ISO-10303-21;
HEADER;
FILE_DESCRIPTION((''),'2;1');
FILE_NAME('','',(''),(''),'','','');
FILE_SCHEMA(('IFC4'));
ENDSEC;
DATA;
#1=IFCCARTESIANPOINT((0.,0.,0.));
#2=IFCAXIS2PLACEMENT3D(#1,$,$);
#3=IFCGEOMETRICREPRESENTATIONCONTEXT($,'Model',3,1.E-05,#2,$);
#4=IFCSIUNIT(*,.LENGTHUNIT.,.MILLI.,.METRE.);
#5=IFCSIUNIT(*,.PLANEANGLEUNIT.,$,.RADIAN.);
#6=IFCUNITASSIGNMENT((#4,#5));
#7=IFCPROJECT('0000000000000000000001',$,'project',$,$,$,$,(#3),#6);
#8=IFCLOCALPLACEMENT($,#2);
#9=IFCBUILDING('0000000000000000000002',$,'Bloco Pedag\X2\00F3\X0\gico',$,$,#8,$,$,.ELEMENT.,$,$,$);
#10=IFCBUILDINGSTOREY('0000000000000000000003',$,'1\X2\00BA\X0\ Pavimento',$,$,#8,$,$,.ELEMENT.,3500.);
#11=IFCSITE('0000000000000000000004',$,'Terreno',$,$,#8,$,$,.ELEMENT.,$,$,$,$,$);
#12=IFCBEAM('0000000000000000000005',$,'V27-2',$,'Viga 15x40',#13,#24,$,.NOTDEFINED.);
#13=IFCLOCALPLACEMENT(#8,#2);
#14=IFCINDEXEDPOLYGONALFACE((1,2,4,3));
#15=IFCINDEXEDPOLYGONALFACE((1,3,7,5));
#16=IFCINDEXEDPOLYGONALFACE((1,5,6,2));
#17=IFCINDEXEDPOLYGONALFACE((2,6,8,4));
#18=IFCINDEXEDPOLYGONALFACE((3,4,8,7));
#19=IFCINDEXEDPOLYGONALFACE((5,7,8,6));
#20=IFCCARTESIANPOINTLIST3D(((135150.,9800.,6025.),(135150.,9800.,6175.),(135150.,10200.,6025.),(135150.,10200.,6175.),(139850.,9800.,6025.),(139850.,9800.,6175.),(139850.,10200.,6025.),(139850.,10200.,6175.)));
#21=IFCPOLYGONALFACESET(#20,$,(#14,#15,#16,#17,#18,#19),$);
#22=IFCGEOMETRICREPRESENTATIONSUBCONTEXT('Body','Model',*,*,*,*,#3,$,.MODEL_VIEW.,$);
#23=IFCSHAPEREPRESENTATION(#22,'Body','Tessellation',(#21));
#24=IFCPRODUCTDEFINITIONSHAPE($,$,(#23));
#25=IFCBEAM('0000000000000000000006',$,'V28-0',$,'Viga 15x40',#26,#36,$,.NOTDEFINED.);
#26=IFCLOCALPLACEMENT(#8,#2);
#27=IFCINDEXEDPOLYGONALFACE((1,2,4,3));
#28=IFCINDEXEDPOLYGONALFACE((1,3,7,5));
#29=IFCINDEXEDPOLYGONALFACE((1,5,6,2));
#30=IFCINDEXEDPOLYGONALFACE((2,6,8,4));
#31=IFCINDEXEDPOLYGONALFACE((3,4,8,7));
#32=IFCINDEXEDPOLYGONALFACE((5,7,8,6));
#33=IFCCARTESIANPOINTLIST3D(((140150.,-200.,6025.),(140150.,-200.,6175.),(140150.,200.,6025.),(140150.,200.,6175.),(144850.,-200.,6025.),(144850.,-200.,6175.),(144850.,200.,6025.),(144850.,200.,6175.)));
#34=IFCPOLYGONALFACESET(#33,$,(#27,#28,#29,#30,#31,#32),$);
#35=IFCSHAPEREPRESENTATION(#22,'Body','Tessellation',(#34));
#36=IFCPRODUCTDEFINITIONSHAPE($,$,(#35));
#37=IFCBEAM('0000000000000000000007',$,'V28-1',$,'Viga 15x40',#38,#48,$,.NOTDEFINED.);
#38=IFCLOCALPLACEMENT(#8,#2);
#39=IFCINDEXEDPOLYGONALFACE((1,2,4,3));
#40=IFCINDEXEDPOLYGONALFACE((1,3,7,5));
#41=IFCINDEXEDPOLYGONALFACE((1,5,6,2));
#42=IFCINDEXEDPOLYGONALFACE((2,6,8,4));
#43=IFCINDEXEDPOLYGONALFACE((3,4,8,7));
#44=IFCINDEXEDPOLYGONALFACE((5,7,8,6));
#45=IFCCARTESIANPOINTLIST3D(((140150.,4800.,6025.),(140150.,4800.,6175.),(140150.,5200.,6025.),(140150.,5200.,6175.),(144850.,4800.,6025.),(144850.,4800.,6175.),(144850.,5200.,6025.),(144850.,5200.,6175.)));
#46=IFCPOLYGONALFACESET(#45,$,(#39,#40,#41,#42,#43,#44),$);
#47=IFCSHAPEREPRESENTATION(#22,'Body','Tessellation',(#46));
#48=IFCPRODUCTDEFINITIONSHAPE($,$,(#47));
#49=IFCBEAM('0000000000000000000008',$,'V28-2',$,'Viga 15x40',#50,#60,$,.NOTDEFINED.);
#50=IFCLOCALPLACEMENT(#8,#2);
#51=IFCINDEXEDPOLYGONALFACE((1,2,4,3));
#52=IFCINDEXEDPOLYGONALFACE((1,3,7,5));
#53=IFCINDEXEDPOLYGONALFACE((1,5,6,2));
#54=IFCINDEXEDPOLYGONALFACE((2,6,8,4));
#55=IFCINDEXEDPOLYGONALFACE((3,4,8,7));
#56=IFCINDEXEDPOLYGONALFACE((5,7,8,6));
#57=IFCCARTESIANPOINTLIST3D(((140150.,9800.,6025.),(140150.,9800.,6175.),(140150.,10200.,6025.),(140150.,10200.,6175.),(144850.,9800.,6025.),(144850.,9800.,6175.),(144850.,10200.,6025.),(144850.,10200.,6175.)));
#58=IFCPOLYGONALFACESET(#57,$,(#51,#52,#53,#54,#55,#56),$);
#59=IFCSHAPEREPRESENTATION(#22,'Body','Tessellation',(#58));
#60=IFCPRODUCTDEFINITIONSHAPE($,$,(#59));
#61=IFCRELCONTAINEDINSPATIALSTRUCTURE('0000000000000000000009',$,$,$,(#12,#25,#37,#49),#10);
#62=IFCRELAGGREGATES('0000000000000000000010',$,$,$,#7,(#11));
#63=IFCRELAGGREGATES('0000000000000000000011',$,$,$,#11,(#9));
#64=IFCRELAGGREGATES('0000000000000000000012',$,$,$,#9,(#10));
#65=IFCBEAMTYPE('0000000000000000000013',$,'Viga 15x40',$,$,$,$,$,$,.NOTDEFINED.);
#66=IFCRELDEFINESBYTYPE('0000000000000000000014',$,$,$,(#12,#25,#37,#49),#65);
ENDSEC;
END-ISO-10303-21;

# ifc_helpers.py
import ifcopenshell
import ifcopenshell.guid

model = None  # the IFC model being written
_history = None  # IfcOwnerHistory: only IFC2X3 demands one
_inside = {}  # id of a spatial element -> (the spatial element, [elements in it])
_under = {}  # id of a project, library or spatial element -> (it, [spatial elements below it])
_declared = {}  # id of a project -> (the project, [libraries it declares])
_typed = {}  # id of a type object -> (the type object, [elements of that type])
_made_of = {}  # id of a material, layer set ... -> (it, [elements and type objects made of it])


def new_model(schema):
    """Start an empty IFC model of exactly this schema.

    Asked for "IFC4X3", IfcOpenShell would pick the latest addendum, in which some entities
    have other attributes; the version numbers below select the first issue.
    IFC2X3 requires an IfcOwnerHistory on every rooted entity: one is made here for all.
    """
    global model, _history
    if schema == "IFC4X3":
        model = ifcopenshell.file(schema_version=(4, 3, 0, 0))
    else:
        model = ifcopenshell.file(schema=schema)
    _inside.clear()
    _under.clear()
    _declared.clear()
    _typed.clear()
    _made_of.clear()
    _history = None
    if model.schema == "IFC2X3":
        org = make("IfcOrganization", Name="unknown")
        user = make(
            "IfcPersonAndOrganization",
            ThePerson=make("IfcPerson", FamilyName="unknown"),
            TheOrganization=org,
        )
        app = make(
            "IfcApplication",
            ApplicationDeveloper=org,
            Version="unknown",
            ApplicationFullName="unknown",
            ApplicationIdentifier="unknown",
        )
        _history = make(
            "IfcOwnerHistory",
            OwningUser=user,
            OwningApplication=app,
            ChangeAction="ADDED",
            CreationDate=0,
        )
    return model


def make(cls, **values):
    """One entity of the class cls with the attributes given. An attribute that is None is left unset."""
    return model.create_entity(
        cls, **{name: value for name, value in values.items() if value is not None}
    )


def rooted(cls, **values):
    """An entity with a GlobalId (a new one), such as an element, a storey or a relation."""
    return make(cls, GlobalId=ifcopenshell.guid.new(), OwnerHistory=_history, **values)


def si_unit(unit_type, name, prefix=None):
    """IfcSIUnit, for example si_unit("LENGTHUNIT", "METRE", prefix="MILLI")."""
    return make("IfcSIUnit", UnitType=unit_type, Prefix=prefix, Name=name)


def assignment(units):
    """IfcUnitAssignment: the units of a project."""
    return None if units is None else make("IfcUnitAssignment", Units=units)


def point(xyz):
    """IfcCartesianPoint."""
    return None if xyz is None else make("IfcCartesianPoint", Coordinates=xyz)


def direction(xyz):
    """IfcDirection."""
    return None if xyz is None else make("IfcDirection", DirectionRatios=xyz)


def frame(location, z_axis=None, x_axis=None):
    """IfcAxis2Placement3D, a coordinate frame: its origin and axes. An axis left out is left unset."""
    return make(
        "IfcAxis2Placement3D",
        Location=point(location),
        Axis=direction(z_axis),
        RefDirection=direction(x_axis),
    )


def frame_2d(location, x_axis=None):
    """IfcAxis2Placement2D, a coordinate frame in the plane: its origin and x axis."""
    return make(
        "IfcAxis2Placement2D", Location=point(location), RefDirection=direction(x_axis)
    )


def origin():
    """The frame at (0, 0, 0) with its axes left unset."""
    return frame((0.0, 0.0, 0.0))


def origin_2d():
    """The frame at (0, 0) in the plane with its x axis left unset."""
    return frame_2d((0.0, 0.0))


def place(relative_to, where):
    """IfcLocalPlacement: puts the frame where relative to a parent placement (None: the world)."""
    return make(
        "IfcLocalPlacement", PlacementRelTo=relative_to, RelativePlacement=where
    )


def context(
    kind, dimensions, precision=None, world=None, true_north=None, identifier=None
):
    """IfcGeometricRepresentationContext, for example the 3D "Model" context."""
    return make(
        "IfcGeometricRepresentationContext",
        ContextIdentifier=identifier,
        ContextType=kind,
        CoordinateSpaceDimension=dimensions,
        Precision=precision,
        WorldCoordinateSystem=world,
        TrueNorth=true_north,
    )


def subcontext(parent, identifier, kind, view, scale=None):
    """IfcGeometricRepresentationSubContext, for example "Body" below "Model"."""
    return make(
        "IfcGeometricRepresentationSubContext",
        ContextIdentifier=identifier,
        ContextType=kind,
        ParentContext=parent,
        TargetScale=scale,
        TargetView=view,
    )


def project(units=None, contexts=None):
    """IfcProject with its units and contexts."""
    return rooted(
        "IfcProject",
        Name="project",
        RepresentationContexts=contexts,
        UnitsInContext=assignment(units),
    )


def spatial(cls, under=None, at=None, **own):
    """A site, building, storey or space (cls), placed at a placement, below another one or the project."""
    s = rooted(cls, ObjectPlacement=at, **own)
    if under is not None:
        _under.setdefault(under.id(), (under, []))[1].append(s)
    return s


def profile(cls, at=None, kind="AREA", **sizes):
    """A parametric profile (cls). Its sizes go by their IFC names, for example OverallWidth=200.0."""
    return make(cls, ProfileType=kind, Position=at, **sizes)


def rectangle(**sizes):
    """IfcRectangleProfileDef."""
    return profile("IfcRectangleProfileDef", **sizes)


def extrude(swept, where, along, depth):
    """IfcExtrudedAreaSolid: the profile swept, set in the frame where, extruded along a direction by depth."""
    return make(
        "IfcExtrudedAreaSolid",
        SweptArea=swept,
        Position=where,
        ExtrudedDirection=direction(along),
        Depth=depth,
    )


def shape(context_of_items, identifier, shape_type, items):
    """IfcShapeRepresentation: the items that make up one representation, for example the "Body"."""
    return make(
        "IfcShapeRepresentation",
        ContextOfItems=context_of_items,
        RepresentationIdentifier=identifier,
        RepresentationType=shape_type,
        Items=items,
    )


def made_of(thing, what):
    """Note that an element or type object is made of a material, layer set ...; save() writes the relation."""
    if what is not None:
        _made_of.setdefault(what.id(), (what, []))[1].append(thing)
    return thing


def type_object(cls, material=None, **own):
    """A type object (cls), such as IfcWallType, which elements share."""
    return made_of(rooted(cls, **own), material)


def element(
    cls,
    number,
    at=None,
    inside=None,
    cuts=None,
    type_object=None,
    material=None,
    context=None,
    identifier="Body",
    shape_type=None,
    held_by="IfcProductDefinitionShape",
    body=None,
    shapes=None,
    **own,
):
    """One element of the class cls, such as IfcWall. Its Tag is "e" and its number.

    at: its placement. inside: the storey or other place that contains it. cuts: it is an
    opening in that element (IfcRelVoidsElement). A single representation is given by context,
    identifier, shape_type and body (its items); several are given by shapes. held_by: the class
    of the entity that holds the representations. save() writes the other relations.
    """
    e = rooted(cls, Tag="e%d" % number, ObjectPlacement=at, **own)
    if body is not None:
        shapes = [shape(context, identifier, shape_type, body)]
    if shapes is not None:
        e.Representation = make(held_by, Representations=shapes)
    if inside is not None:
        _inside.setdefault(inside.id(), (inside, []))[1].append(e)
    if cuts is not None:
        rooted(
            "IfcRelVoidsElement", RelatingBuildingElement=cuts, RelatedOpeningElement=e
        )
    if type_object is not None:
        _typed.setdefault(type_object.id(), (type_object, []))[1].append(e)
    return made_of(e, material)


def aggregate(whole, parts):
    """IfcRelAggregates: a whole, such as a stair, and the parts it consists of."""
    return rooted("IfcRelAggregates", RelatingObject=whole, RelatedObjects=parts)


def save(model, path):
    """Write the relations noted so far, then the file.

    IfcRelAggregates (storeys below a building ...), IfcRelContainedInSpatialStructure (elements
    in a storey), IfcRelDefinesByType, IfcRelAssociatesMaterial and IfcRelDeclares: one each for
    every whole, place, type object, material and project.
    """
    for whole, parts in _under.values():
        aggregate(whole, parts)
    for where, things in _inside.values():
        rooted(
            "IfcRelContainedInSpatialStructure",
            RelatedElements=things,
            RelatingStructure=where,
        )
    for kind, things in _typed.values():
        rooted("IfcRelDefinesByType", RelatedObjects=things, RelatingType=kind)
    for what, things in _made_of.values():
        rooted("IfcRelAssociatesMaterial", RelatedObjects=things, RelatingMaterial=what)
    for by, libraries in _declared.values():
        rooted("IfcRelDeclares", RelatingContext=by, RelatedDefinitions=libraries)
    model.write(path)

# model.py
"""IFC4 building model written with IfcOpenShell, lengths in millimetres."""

from ifc_helpers import new_model, si_unit, frame, origin, origin_2d, place, context, subcontext, project, spatial, rectangle, extrude, type_object, element, save


model = new_model("IFC4")

# Units and contexts
model_context = context("Model", 3, precision=1e-05, world=origin())
body_context = subcontext(model_context, "Body", "Model", "MODEL_VIEW")
ifc_project = project(units=[si_unit("LENGTHUNIT", "METRE", prefix="MILLI"), si_unit("PLANEANGLEUNIT", "RADIAN")], contexts=[model_context])

# Site, building, storey
placement = place(None, origin())
site = spatial("IfcSite", under=ifc_project, at=placement, Name="Terreno", CompositionType="ELEMENT")
building = spatial("IfcBuilding", under=site, at=placement, Name="Bloco Pedagógico", CompositionType="ELEMENT")
storey = spatial("IfcBuildingStorey", under=building, at=placement, Name="1º Pavimento", CompositionType="ELEMENT", Elevation=3500.0)

# Beams
beam_type = type_object("IfcBeamType", Name="Viga 15x40", PredefinedType="NOTDEFINED")
for number, where, z_axis, x_axis, name in (
    (1, (135150.0, 10000.0, 6100.0), (1.0, 0.0, 0.0), (0.0, 1.0, 0.0), "V27-2"),
    (2, (140150.0, 0.0, 6100.0), (1.0, 0.0, 0.0), (0.0, 1.0, 0.0), "V28-0"),
    (3, (140150.0, 5000.0, 6100.0), (1.0, 0.0, 0.0), (0.0, 1.0, 0.0), "V28-1"),
    (4, (140150.0, 10000.0, 6100.0), (1.0, 0.0, 0.0), (0.0, 1.0, 0.0), "V28-2"),
):
    element("IfcBeam", number, at=place(None, frame(where, z_axis=z_axis, x_axis=x_axis)), inside=storey, type_object=beam_type, Name=name, ObjectType="Viga 15x40", PredefinedType="NOTDEFINED", context=body_context, shape_type="SweptSolid", body=[
        extrude(rectangle(XDim=400.0, YDim=150.0, at=origin_2d()), None, (0.0, 0.0, 1.0), 4700.0),
    ])

save(model, "model.ifc")
